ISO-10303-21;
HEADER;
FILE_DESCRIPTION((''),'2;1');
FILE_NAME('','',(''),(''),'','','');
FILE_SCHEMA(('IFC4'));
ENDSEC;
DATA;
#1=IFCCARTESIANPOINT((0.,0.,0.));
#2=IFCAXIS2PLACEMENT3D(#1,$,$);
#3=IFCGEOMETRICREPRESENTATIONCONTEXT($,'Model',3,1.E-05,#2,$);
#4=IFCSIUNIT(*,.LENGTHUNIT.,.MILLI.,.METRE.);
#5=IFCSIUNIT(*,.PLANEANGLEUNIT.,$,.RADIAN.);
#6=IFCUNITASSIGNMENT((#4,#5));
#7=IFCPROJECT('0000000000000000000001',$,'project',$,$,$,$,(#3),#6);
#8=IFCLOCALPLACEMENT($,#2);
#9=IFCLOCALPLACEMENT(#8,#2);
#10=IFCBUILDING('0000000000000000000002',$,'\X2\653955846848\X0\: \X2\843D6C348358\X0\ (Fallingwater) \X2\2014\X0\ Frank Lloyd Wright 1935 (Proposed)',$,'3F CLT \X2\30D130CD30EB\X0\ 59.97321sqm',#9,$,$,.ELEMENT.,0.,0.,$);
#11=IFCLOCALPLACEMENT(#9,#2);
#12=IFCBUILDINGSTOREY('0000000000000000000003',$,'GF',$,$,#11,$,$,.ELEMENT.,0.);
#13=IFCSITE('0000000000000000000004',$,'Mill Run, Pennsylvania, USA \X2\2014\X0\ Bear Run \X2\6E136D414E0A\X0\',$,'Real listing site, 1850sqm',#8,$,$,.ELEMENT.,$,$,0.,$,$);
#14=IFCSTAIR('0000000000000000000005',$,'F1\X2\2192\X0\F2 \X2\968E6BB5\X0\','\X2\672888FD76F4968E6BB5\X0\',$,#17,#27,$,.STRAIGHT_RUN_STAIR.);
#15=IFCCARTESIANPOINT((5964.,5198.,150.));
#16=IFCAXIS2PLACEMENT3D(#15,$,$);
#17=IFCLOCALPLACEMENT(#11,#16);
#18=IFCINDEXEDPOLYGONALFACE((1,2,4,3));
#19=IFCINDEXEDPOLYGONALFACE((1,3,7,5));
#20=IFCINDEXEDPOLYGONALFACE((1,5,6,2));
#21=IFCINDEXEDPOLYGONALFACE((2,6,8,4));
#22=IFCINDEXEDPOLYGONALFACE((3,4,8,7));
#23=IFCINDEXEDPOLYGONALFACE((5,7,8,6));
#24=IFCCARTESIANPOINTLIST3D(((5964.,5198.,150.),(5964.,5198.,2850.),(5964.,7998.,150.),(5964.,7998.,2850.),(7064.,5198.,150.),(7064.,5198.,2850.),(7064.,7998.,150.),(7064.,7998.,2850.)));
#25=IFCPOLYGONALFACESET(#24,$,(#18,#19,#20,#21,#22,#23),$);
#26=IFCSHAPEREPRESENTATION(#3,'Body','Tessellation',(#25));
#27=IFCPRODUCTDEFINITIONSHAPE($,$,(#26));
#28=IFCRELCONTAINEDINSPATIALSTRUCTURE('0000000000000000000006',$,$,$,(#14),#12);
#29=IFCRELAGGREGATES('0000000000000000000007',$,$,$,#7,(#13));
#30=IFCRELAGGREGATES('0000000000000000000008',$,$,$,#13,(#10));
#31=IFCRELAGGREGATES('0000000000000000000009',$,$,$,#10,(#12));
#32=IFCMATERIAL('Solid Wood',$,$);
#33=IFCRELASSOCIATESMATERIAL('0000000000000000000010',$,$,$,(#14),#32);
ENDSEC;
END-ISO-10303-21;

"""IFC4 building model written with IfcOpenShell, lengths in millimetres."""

from ifc_helpers import new_model, si_unit, frame, frame_2d, origin, place, context, project, spatial, rectangle, extrude, material, element, save


model = new_model("IFC4")

# Units and contexts
model_context = context("Model", 3, precision=1e-05, world=origin())
ifc_project = project(units=[si_unit("LENGTHUNIT", "METRE", prefix="MILLI"), si_unit("PLANEANGLEUNIT", "RADIAN")], contexts=[model_context])

# Site, building, storey
site_placement = place(None, origin())
site = spatial("IfcSite", under=ifc_project, at=site_placement, Name="Mill Run, Pennsylvania, USA — Bear Run 渓流上", ObjectType="Real listing site, 1850sqm", CompositionType="ELEMENT", RefElevation=0.0)
building_placement = place(site_placement, origin())
building = spatial("IfcBuilding", under=site, at=building_placement, Name="改善案: 落水荘 (Fallingwater) — Frank Lloyd Wright 1935 (Proposed)", ObjectType="3F CLT パネル 59.97321sqm", CompositionType="ELEMENT", ElevationOfRefHeight=0.0, ElevationOfTerrain=0.0)
storey_placement = place(building_placement, origin())
storey = spatial("IfcBuildingStorey", under=building, at=storey_placement, Name="GF", CompositionType="ELEMENT", Elevation=0.0)

# Shared definitions
ifc_material_1 = material(Name="Solid Wood")

# Stair
stair_placement = place(storey_placement, frame((5964.0, 5198.0, 150.0)))
element("IfcStair", 1, at=stair_placement, inside=storey, material=ifc_material_1, Name="F1→F2 階段", Description="木製直階段", PredefinedType="STRAIGHT_RUN_STAIR", context=model_context, shape_type="SweptSolid", body=[
    extrude(rectangle(XDim=1100.0, YDim=2800.0, at=frame_2d((550.0, 1400.0))), frame((5964.0, 5198.0, 150.0)), (0.0, 0.0, 1.0), 2700.0),
])

save(model, "model.ifc")
